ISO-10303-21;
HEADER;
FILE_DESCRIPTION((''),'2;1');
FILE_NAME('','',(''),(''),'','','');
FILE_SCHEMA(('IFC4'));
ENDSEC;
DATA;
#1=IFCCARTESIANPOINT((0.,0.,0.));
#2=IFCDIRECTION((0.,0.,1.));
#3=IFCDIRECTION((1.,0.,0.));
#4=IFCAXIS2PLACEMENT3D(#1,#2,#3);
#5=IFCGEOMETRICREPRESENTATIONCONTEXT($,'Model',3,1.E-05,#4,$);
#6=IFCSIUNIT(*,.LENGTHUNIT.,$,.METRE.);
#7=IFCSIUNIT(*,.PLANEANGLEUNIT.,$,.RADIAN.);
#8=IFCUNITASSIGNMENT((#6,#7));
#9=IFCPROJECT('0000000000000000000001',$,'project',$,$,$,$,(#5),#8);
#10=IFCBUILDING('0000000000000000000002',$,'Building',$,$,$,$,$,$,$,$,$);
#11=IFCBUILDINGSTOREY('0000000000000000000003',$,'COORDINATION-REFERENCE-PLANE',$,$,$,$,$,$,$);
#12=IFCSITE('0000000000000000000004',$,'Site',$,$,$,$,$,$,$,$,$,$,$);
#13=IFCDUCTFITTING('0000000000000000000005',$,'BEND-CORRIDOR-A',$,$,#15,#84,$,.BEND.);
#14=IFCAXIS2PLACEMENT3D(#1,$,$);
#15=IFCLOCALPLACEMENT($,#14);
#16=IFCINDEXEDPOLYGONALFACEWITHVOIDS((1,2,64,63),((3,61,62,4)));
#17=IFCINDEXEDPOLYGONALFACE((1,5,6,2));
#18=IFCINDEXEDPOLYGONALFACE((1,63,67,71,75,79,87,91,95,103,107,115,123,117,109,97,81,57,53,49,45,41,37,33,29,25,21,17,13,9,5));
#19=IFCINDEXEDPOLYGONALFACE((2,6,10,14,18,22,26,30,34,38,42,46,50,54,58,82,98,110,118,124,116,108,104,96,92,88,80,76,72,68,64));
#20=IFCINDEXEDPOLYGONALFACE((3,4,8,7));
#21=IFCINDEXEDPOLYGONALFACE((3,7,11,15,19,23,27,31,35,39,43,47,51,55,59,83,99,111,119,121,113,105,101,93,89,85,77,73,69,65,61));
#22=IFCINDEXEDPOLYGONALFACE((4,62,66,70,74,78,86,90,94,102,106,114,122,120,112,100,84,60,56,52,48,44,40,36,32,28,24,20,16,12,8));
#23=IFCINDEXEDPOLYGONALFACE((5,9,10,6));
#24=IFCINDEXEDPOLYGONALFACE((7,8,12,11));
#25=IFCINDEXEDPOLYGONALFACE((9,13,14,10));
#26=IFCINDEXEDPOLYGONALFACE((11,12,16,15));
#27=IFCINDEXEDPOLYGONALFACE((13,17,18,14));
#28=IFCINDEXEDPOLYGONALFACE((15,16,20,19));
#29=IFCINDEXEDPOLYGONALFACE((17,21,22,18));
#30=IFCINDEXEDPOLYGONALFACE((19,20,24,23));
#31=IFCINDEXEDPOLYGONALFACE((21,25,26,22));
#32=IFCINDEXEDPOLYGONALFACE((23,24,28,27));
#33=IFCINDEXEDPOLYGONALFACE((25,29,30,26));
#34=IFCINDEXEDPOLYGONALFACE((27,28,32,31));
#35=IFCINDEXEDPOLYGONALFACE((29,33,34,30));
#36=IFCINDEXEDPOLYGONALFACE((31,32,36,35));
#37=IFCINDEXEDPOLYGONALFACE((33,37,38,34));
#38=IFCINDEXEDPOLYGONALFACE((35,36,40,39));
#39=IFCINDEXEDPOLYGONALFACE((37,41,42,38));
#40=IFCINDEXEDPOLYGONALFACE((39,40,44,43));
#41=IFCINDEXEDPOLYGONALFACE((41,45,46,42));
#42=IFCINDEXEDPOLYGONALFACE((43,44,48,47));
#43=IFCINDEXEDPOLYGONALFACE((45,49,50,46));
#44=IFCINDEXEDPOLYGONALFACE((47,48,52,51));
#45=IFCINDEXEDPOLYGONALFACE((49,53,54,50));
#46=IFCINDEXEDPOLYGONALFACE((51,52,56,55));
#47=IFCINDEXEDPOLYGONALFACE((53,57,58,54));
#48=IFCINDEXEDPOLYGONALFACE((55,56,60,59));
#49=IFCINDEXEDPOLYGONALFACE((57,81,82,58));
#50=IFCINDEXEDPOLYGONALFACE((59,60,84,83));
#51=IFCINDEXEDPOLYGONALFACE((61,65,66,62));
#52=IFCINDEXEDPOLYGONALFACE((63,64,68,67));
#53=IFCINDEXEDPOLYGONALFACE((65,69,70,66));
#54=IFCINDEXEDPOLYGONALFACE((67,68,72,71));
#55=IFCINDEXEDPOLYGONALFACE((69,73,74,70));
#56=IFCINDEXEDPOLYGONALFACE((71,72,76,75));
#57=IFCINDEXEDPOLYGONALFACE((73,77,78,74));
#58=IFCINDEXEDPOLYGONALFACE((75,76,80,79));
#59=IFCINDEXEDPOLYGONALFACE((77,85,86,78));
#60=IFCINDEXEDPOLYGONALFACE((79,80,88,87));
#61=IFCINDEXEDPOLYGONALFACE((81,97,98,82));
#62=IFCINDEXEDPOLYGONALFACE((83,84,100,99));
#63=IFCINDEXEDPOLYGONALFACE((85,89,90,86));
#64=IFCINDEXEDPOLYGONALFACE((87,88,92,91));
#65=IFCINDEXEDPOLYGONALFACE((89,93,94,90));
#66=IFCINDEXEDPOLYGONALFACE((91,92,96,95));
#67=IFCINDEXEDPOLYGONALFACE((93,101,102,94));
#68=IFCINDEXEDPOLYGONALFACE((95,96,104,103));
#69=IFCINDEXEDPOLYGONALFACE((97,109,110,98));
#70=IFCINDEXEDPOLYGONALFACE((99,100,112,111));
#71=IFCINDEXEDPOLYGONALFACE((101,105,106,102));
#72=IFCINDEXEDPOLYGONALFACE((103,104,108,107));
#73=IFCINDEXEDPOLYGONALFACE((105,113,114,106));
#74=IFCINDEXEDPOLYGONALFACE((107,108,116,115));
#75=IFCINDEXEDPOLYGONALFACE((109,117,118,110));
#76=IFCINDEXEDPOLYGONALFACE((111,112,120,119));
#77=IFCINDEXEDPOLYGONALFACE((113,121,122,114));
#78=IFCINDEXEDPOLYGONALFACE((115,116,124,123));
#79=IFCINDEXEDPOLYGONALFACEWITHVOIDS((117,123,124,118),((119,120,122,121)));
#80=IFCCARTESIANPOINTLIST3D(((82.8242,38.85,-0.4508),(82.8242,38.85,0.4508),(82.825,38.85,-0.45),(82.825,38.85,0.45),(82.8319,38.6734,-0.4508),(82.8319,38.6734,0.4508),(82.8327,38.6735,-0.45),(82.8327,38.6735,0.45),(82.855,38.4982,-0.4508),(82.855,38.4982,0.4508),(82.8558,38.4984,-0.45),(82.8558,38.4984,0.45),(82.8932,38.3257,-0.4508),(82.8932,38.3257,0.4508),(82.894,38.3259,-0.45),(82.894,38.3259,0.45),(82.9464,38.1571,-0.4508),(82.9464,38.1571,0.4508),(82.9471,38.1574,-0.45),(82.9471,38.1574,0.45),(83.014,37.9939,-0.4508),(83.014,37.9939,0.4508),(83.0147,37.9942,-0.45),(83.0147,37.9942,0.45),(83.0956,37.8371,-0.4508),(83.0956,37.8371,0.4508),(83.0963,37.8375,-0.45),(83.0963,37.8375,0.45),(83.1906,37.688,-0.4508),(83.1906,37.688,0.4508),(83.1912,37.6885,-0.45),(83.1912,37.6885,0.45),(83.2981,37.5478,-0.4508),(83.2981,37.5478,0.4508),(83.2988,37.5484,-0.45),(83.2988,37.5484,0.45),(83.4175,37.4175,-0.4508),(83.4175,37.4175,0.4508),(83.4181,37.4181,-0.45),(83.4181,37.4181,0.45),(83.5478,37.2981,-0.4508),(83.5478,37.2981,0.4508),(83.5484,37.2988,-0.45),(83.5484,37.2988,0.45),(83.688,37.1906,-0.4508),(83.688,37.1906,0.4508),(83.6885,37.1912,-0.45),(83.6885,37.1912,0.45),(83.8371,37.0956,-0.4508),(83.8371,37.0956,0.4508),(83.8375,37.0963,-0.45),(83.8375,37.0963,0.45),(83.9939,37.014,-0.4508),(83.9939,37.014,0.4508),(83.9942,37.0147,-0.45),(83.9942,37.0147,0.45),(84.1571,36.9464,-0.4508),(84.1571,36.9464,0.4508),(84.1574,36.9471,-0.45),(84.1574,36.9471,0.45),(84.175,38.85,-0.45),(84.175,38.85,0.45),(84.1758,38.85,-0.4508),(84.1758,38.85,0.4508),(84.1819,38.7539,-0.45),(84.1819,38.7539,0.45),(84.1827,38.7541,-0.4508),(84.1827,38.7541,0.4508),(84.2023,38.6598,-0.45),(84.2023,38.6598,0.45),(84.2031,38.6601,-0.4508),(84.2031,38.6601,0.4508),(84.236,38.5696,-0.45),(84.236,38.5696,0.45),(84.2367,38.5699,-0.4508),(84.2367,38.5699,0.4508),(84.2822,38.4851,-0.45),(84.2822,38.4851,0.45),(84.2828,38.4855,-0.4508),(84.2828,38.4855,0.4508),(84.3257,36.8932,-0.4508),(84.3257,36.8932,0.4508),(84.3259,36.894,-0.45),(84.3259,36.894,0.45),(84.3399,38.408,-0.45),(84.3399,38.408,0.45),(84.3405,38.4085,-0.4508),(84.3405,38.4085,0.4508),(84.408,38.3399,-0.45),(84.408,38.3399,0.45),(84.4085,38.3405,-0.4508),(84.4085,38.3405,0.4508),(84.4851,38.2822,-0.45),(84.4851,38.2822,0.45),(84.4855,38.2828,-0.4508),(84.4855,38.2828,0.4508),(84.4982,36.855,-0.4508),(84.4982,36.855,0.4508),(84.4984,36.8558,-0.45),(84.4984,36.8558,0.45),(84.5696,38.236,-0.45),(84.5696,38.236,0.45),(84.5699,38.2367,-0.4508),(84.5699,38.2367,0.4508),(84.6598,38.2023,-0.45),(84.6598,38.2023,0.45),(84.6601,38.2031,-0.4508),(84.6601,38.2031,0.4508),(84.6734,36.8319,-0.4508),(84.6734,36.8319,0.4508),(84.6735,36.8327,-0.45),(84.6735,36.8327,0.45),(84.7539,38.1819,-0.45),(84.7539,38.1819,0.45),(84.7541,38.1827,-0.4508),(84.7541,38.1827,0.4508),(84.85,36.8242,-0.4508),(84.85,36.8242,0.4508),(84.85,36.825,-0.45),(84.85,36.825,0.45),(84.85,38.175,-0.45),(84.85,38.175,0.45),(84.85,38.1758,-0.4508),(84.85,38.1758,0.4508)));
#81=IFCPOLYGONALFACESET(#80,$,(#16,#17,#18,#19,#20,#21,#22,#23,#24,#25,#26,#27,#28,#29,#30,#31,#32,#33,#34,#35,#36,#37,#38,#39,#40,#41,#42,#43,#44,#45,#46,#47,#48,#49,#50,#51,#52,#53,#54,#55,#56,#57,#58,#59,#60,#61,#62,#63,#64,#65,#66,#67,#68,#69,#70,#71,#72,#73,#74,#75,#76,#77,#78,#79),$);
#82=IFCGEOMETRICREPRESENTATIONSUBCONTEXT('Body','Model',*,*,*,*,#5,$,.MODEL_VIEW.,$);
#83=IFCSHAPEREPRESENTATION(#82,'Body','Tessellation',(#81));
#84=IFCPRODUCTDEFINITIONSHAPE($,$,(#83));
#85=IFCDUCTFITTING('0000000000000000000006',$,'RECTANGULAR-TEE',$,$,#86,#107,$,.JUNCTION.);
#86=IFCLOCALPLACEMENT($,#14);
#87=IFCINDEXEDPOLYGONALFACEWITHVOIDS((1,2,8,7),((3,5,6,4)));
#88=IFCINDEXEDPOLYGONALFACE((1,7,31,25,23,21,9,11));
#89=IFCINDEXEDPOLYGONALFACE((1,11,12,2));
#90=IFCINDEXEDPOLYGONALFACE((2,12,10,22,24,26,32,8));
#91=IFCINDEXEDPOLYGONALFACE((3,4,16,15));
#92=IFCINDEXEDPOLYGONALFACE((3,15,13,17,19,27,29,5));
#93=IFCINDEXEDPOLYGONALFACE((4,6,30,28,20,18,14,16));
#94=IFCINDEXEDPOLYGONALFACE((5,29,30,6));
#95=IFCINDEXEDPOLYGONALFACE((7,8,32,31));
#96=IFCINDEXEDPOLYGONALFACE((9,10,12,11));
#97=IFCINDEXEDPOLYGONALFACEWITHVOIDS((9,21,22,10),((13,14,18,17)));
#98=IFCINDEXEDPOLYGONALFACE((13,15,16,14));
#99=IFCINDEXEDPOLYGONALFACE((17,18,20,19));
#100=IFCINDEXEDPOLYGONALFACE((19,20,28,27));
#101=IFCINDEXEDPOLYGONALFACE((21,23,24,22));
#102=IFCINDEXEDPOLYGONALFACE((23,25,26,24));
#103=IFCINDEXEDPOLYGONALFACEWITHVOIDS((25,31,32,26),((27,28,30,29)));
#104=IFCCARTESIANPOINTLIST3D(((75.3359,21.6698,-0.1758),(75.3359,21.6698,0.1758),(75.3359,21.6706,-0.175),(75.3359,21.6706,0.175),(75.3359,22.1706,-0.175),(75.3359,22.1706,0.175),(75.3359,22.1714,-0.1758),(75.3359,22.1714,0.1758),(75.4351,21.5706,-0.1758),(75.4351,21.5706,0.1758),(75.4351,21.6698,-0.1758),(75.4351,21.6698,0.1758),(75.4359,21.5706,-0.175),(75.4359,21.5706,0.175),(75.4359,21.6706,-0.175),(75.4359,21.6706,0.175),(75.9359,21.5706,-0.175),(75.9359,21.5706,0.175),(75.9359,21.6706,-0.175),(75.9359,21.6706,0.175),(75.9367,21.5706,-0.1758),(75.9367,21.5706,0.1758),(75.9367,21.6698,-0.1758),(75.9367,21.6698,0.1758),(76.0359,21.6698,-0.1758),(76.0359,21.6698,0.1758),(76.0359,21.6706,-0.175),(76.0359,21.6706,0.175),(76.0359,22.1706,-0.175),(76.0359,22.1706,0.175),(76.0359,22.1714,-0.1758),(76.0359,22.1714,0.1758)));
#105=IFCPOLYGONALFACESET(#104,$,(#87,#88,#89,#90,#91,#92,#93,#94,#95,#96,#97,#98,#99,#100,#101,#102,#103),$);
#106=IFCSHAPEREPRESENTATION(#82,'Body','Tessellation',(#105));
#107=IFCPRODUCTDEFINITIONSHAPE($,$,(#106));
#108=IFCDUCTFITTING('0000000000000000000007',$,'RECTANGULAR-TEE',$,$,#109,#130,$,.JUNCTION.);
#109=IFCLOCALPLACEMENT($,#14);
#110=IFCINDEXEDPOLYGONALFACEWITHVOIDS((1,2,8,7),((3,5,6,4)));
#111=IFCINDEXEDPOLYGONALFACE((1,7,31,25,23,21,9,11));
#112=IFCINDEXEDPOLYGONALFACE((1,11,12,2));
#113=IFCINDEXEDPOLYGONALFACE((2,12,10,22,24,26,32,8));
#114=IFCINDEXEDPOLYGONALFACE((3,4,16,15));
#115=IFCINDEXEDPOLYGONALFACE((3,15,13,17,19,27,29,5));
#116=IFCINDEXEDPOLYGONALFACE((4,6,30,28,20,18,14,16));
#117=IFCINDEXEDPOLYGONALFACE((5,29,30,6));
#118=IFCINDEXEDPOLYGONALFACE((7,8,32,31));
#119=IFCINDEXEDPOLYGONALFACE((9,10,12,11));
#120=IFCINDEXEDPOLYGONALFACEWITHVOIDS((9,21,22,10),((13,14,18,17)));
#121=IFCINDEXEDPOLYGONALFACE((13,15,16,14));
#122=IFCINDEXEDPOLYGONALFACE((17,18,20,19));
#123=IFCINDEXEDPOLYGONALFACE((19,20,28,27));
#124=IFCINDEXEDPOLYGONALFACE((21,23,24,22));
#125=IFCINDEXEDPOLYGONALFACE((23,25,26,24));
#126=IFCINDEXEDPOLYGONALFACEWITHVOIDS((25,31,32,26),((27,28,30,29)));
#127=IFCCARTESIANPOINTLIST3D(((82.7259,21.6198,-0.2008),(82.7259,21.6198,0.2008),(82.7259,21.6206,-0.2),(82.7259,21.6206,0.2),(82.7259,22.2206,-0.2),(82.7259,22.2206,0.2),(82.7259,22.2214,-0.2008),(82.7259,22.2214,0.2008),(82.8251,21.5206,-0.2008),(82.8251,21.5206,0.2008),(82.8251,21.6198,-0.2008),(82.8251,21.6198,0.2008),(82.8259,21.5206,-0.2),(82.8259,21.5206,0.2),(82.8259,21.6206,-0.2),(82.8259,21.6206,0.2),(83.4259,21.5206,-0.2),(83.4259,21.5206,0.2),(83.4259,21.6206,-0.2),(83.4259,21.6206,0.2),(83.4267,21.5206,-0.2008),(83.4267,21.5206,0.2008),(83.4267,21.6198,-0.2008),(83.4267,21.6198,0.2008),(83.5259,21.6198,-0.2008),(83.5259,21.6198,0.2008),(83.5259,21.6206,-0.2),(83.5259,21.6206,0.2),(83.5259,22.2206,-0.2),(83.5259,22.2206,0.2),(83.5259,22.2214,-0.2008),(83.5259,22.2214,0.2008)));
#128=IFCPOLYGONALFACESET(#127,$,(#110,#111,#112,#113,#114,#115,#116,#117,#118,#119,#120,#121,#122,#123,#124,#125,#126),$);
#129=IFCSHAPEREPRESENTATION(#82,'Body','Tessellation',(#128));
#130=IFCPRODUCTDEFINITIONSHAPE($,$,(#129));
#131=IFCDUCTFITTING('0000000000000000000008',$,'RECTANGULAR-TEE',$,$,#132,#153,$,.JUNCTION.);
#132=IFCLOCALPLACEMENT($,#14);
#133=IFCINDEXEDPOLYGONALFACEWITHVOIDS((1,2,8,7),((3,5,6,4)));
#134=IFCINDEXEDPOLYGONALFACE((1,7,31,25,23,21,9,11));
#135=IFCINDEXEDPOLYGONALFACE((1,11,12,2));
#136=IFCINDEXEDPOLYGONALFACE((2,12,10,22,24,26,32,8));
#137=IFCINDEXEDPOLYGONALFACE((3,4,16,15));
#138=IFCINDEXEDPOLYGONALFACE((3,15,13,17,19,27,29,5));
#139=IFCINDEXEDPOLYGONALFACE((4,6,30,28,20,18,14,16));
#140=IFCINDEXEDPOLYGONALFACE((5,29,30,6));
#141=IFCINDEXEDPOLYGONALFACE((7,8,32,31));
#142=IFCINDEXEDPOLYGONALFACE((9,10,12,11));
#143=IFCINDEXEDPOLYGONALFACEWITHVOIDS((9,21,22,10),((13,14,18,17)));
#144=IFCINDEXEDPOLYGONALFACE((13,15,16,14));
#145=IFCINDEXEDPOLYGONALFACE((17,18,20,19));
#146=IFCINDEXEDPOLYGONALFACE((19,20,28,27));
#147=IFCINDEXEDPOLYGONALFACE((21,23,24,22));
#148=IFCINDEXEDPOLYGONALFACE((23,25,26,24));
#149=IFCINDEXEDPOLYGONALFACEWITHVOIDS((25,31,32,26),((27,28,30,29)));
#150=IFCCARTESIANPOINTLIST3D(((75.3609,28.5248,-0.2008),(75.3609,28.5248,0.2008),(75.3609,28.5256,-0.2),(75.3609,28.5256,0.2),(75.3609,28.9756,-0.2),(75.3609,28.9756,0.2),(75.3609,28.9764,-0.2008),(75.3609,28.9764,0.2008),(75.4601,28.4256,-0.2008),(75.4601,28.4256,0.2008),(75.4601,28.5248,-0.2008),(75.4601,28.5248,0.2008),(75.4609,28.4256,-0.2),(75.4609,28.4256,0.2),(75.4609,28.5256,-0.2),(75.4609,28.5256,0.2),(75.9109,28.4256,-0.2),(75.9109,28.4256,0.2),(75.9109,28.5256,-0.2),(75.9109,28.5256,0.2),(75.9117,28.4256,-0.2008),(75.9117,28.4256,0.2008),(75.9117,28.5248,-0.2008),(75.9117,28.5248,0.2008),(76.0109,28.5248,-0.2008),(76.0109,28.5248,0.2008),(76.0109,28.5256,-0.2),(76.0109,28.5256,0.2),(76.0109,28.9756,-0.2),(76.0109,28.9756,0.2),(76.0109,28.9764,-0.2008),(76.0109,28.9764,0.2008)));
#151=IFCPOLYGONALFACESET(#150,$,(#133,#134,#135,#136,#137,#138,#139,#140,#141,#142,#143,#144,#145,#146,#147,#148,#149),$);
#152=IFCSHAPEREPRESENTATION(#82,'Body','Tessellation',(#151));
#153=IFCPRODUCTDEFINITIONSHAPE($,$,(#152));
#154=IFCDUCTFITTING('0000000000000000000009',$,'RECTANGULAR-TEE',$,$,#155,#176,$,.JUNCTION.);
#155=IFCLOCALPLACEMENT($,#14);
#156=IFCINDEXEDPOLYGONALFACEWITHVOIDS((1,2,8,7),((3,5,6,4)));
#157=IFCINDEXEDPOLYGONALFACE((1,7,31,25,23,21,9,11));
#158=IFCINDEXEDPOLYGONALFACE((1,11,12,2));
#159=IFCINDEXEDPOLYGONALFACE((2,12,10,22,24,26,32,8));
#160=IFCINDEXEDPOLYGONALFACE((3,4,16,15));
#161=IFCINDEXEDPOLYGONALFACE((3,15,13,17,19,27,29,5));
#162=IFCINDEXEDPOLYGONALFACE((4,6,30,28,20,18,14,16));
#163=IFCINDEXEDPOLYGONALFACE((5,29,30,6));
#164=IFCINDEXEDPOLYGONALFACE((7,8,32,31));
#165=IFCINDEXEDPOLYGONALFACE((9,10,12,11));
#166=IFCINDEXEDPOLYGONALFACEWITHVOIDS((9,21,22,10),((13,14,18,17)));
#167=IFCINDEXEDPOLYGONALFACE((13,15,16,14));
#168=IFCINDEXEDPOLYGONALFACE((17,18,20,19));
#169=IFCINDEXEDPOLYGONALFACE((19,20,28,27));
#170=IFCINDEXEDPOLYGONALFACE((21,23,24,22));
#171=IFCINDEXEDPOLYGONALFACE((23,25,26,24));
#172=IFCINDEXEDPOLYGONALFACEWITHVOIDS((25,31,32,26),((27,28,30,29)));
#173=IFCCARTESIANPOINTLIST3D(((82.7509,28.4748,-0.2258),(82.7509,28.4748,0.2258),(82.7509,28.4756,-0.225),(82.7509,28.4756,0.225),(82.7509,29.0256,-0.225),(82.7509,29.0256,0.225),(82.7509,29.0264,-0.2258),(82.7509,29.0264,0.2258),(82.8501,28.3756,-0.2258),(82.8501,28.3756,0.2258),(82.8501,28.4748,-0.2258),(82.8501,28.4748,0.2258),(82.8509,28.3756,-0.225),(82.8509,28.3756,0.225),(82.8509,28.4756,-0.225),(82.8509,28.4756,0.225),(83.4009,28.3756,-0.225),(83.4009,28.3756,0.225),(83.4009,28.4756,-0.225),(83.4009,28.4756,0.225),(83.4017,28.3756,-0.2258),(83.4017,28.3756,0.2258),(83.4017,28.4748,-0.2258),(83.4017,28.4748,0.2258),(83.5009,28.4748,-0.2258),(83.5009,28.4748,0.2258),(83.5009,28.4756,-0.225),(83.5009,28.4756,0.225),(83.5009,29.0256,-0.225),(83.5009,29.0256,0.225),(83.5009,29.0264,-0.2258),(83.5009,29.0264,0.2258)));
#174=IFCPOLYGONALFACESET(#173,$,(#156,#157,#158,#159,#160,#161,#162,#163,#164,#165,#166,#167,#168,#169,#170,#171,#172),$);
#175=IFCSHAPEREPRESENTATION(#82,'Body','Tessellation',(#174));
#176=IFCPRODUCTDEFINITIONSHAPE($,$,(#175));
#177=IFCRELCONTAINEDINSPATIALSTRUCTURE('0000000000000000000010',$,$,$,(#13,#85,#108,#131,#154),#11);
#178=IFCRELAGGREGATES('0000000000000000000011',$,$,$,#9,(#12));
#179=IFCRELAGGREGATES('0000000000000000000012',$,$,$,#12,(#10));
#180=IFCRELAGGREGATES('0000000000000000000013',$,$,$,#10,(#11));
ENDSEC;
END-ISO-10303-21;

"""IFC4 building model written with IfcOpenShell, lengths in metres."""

from ifc_helpers import new_model, entity, si_unit, frame, origin_with_axes, place, context, subcontext, project, spatial, rectangle, extrude, boolean, element, save


model = new_model("IFC4")

# Units and contexts
model_context = context("Model", 3, precision=1e-05, world=origin_with_axes())
body_context = subcontext(model_context, "Body", "Model", "MODEL_VIEW")
ifc_project = project(units=[si_unit("LENGTHUNIT", "METRE"), si_unit("PLANEANGLEUNIT", "RADIAN")], contexts=[model_context])

# Site, building, storey
site = spatial("IfcSite", under=ifc_project, Name="Site")
building = spatial("IfcBuilding", under=site, Name="Building")
storey = spatial("IfcBuildingStorey", under=building, Name="COORDINATION-REFERENCE-PLANE")

# Duct fittings
duct_fitting_1_placement = place(None, frame((84.85, 38.85, 0.0), z_axis=(0.0, 0.0, 1.0), x_axis=(-1.0, 0.0, 0.0)))
cartesian_point_1 = entity("IfcCartesianPoint", [0.0, 0.0, 0.0])
element("IfcDuctFitting", 1, at=duct_fitting_1_placement, inside=storey, Name="BEND-CORRIDOR-A", PredefinedType="BEND", context=body_context, shape_type="SweptSolid", body=[
    entity("IfcRevolvedAreaSolid", entity("IfcRectangleHollowProfileDef", "AREA", None, entity("IfcAxis2Placement2D", entity("IfcCartesianPoint", [1.35, 0.0])), 1.3516, 0.9016, 0.0008), entity("IfcAxis2Placement3D", cartesian_point_1, entity("IfcDirection", [0.0, -1.0, 0.0]), entity("IfcDirection", [1.0, 0.0, 0.0])), entity("IfcAxis1Placement", cartesian_point_1, entity("IfcDirection", [0.0, 1.0, 0.0])), 1.570796),
])
duct_fitting_2_placement = place(None, frame((75.6859, 21.9206, 0.0), z_axis=(-1.0, 0.0, 0.0), x_axis=(0.0, -1.0, 0.0)))
solid_1 = boolean("UNION", extrude(rectangle(XDim=0.5, YDim=0.35), frame((0.0, 0.0, -0.35), z_axis=(0.0, 0.0, 1.0), x_axis=(1.0, 0.0, 0.0)), (0.0, 0.0, 1.0), 0.7), extrude(rectangle(XDim=0.5, YDim=0.35), frame((0.0, 0.0, 0.0), z_axis=(1.0, 0.0, 0.0), x_axis=(0.0, 0.0, -1.0)), (0.0, 0.0, 1.0), 0.35))
element("IfcDuctFitting", 2, at=duct_fitting_2_placement, inside=storey, Name="RECTANGULAR-TEE", PredefinedType="JUNCTION", context=body_context, shape_type="CSG", body=[
    boolean("DIFFERENCE", boolean("UNION", extrude(rectangle(XDim=0.5016, YDim=0.3516), frame((0.0, 0.0, -0.35), z_axis=(0.0, 0.0, 1.0), x_axis=(1.0, 0.0, 0.0)), (0.0, 0.0, 1.0), 0.7), extrude(rectangle(XDim=0.5016, YDim=0.3516), frame((0.0, 0.0, 0.0), z_axis=(1.0, 0.0, 0.0), x_axis=(0.0, 0.0, -1.0)), (0.0, 0.0, 1.0), 0.35)), solid_1),
])
duct_fitting_3_placement = place(None, frame((83.1259, 21.9206, 0.0), z_axis=(-1.0, 0.0, 0.0), x_axis=(0.0, -1.0, 0.0)))
solid_2 = boolean("UNION", extrude(rectangle(XDim=0.6, YDim=0.4), frame((0.0, 0.0, -0.4), z_axis=(0.0, 0.0, 1.0), x_axis=(1.0, 0.0, 0.0)), (0.0, 0.0, 1.0), 0.8), extrude(rectangle(XDim=0.6, YDim=0.4), frame((0.0, 0.0, 0.0), z_axis=(1.0, 0.0, 0.0), x_axis=(0.0, 0.0, -1.0)), (0.0, 0.0, 1.0), 0.4))
element("IfcDuctFitting", 3, at=duct_fitting_3_placement, inside=storey, Name="RECTANGULAR-TEE", PredefinedType="JUNCTION", context=body_context, shape_type="CSG", body=[
    boolean("DIFFERENCE", boolean("UNION", extrude(rectangle(XDim=0.6016, YDim=0.4016), frame((0.0, 0.0, -0.4), z_axis=(0.0, 0.0, 1.0), x_axis=(1.0, 0.0, 0.0)), (0.0, 0.0, 1.0), 0.8), extrude(rectangle(XDim=0.6016, YDim=0.4016), frame((0.0, 0.0, 0.0), z_axis=(1.0, 0.0, 0.0), x_axis=(0.0, 0.0, -1.0)), (0.0, 0.0, 1.0), 0.4)), solid_2),
])
duct_fitting_4_placement = place(None, frame((75.6859, 28.7506, 0.0), z_axis=(-1.0, 0.0, 0.0), x_axis=(0.0, -1.0, 0.0)))
solid_3 = boolean("UNION", extrude(rectangle(XDim=0.45, YDim=0.4), frame((0.0, 0.0, -0.325), z_axis=(0.0, 0.0, 1.0), x_axis=(1.0, 0.0, 0.0)), (0.0, 0.0, 1.0), 0.65), extrude(rectangle(XDim=0.45, YDim=0.4), frame((0.0, 0.0, 0.0), z_axis=(1.0, 0.0, 0.0), x_axis=(0.0, 0.0, -1.0)), (0.0, 0.0, 1.0), 0.325))
element("IfcDuctFitting", 4, at=duct_fitting_4_placement, inside=storey, Name="RECTANGULAR-TEE", PredefinedType="JUNCTION", context=body_context, shape_type="CSG", body=[
    boolean("DIFFERENCE", boolean("UNION", extrude(rectangle(XDim=0.4516, YDim=0.4016), frame((0.0, 0.0, -0.325), z_axis=(0.0, 0.0, 1.0), x_axis=(1.0, 0.0, 0.0)), (0.0, 0.0, 1.0), 0.65), extrude(rectangle(XDim=0.4516, YDim=0.4016), frame((0.0, 0.0, 0.0), z_axis=(1.0, 0.0, 0.0), x_axis=(0.0, 0.0, -1.0)), (0.0, 0.0, 1.0), 0.325)), solid_3),
])
duct_fitting_5_placement = place(None, frame((83.1259, 28.7506, 0.0), z_axis=(-1.0, 0.0, 0.0), x_axis=(0.0, -1.0, 0.0)))
solid_4 = boolean("UNION", extrude(rectangle(XDim=0.55, YDim=0.45), frame((0.0, 0.0, -0.375), z_axis=(0.0, 0.0, 1.0), x_axis=(1.0, 0.0, 0.0)), (0.0, 0.0, 1.0), 0.75), extrude(rectangle(XDim=0.55, YDim=0.45), frame((0.0, 0.0, 0.0), z_axis=(1.0, 0.0, 0.0), x_axis=(0.0, 0.0, -1.0)), (0.0, 0.0, 1.0), 0.375))
element("IfcDuctFitting", 5, at=duct_fitting_5_placement, inside=storey, Name="RECTANGULAR-TEE", PredefinedType="JUNCTION", context=body_context, shape_type="CSG", body=[
    boolean("DIFFERENCE", boolean("UNION", extrude(rectangle(XDim=0.5516, YDim=0.4516), frame((0.0, 0.0, -0.375), z_axis=(0.0, 0.0, 1.0), x_axis=(1.0, 0.0, 0.0)), (0.0, 0.0, 1.0), 0.75), extrude(rectangle(XDim=0.5516, YDim=0.4516), frame((0.0, 0.0, 0.0), z_axis=(1.0, 0.0, 0.0), x_axis=(0.0, 0.0, -1.0)), (0.0, 0.0, 1.0), 0.375)), solid_4),
])

save(model, "model.ifc")
